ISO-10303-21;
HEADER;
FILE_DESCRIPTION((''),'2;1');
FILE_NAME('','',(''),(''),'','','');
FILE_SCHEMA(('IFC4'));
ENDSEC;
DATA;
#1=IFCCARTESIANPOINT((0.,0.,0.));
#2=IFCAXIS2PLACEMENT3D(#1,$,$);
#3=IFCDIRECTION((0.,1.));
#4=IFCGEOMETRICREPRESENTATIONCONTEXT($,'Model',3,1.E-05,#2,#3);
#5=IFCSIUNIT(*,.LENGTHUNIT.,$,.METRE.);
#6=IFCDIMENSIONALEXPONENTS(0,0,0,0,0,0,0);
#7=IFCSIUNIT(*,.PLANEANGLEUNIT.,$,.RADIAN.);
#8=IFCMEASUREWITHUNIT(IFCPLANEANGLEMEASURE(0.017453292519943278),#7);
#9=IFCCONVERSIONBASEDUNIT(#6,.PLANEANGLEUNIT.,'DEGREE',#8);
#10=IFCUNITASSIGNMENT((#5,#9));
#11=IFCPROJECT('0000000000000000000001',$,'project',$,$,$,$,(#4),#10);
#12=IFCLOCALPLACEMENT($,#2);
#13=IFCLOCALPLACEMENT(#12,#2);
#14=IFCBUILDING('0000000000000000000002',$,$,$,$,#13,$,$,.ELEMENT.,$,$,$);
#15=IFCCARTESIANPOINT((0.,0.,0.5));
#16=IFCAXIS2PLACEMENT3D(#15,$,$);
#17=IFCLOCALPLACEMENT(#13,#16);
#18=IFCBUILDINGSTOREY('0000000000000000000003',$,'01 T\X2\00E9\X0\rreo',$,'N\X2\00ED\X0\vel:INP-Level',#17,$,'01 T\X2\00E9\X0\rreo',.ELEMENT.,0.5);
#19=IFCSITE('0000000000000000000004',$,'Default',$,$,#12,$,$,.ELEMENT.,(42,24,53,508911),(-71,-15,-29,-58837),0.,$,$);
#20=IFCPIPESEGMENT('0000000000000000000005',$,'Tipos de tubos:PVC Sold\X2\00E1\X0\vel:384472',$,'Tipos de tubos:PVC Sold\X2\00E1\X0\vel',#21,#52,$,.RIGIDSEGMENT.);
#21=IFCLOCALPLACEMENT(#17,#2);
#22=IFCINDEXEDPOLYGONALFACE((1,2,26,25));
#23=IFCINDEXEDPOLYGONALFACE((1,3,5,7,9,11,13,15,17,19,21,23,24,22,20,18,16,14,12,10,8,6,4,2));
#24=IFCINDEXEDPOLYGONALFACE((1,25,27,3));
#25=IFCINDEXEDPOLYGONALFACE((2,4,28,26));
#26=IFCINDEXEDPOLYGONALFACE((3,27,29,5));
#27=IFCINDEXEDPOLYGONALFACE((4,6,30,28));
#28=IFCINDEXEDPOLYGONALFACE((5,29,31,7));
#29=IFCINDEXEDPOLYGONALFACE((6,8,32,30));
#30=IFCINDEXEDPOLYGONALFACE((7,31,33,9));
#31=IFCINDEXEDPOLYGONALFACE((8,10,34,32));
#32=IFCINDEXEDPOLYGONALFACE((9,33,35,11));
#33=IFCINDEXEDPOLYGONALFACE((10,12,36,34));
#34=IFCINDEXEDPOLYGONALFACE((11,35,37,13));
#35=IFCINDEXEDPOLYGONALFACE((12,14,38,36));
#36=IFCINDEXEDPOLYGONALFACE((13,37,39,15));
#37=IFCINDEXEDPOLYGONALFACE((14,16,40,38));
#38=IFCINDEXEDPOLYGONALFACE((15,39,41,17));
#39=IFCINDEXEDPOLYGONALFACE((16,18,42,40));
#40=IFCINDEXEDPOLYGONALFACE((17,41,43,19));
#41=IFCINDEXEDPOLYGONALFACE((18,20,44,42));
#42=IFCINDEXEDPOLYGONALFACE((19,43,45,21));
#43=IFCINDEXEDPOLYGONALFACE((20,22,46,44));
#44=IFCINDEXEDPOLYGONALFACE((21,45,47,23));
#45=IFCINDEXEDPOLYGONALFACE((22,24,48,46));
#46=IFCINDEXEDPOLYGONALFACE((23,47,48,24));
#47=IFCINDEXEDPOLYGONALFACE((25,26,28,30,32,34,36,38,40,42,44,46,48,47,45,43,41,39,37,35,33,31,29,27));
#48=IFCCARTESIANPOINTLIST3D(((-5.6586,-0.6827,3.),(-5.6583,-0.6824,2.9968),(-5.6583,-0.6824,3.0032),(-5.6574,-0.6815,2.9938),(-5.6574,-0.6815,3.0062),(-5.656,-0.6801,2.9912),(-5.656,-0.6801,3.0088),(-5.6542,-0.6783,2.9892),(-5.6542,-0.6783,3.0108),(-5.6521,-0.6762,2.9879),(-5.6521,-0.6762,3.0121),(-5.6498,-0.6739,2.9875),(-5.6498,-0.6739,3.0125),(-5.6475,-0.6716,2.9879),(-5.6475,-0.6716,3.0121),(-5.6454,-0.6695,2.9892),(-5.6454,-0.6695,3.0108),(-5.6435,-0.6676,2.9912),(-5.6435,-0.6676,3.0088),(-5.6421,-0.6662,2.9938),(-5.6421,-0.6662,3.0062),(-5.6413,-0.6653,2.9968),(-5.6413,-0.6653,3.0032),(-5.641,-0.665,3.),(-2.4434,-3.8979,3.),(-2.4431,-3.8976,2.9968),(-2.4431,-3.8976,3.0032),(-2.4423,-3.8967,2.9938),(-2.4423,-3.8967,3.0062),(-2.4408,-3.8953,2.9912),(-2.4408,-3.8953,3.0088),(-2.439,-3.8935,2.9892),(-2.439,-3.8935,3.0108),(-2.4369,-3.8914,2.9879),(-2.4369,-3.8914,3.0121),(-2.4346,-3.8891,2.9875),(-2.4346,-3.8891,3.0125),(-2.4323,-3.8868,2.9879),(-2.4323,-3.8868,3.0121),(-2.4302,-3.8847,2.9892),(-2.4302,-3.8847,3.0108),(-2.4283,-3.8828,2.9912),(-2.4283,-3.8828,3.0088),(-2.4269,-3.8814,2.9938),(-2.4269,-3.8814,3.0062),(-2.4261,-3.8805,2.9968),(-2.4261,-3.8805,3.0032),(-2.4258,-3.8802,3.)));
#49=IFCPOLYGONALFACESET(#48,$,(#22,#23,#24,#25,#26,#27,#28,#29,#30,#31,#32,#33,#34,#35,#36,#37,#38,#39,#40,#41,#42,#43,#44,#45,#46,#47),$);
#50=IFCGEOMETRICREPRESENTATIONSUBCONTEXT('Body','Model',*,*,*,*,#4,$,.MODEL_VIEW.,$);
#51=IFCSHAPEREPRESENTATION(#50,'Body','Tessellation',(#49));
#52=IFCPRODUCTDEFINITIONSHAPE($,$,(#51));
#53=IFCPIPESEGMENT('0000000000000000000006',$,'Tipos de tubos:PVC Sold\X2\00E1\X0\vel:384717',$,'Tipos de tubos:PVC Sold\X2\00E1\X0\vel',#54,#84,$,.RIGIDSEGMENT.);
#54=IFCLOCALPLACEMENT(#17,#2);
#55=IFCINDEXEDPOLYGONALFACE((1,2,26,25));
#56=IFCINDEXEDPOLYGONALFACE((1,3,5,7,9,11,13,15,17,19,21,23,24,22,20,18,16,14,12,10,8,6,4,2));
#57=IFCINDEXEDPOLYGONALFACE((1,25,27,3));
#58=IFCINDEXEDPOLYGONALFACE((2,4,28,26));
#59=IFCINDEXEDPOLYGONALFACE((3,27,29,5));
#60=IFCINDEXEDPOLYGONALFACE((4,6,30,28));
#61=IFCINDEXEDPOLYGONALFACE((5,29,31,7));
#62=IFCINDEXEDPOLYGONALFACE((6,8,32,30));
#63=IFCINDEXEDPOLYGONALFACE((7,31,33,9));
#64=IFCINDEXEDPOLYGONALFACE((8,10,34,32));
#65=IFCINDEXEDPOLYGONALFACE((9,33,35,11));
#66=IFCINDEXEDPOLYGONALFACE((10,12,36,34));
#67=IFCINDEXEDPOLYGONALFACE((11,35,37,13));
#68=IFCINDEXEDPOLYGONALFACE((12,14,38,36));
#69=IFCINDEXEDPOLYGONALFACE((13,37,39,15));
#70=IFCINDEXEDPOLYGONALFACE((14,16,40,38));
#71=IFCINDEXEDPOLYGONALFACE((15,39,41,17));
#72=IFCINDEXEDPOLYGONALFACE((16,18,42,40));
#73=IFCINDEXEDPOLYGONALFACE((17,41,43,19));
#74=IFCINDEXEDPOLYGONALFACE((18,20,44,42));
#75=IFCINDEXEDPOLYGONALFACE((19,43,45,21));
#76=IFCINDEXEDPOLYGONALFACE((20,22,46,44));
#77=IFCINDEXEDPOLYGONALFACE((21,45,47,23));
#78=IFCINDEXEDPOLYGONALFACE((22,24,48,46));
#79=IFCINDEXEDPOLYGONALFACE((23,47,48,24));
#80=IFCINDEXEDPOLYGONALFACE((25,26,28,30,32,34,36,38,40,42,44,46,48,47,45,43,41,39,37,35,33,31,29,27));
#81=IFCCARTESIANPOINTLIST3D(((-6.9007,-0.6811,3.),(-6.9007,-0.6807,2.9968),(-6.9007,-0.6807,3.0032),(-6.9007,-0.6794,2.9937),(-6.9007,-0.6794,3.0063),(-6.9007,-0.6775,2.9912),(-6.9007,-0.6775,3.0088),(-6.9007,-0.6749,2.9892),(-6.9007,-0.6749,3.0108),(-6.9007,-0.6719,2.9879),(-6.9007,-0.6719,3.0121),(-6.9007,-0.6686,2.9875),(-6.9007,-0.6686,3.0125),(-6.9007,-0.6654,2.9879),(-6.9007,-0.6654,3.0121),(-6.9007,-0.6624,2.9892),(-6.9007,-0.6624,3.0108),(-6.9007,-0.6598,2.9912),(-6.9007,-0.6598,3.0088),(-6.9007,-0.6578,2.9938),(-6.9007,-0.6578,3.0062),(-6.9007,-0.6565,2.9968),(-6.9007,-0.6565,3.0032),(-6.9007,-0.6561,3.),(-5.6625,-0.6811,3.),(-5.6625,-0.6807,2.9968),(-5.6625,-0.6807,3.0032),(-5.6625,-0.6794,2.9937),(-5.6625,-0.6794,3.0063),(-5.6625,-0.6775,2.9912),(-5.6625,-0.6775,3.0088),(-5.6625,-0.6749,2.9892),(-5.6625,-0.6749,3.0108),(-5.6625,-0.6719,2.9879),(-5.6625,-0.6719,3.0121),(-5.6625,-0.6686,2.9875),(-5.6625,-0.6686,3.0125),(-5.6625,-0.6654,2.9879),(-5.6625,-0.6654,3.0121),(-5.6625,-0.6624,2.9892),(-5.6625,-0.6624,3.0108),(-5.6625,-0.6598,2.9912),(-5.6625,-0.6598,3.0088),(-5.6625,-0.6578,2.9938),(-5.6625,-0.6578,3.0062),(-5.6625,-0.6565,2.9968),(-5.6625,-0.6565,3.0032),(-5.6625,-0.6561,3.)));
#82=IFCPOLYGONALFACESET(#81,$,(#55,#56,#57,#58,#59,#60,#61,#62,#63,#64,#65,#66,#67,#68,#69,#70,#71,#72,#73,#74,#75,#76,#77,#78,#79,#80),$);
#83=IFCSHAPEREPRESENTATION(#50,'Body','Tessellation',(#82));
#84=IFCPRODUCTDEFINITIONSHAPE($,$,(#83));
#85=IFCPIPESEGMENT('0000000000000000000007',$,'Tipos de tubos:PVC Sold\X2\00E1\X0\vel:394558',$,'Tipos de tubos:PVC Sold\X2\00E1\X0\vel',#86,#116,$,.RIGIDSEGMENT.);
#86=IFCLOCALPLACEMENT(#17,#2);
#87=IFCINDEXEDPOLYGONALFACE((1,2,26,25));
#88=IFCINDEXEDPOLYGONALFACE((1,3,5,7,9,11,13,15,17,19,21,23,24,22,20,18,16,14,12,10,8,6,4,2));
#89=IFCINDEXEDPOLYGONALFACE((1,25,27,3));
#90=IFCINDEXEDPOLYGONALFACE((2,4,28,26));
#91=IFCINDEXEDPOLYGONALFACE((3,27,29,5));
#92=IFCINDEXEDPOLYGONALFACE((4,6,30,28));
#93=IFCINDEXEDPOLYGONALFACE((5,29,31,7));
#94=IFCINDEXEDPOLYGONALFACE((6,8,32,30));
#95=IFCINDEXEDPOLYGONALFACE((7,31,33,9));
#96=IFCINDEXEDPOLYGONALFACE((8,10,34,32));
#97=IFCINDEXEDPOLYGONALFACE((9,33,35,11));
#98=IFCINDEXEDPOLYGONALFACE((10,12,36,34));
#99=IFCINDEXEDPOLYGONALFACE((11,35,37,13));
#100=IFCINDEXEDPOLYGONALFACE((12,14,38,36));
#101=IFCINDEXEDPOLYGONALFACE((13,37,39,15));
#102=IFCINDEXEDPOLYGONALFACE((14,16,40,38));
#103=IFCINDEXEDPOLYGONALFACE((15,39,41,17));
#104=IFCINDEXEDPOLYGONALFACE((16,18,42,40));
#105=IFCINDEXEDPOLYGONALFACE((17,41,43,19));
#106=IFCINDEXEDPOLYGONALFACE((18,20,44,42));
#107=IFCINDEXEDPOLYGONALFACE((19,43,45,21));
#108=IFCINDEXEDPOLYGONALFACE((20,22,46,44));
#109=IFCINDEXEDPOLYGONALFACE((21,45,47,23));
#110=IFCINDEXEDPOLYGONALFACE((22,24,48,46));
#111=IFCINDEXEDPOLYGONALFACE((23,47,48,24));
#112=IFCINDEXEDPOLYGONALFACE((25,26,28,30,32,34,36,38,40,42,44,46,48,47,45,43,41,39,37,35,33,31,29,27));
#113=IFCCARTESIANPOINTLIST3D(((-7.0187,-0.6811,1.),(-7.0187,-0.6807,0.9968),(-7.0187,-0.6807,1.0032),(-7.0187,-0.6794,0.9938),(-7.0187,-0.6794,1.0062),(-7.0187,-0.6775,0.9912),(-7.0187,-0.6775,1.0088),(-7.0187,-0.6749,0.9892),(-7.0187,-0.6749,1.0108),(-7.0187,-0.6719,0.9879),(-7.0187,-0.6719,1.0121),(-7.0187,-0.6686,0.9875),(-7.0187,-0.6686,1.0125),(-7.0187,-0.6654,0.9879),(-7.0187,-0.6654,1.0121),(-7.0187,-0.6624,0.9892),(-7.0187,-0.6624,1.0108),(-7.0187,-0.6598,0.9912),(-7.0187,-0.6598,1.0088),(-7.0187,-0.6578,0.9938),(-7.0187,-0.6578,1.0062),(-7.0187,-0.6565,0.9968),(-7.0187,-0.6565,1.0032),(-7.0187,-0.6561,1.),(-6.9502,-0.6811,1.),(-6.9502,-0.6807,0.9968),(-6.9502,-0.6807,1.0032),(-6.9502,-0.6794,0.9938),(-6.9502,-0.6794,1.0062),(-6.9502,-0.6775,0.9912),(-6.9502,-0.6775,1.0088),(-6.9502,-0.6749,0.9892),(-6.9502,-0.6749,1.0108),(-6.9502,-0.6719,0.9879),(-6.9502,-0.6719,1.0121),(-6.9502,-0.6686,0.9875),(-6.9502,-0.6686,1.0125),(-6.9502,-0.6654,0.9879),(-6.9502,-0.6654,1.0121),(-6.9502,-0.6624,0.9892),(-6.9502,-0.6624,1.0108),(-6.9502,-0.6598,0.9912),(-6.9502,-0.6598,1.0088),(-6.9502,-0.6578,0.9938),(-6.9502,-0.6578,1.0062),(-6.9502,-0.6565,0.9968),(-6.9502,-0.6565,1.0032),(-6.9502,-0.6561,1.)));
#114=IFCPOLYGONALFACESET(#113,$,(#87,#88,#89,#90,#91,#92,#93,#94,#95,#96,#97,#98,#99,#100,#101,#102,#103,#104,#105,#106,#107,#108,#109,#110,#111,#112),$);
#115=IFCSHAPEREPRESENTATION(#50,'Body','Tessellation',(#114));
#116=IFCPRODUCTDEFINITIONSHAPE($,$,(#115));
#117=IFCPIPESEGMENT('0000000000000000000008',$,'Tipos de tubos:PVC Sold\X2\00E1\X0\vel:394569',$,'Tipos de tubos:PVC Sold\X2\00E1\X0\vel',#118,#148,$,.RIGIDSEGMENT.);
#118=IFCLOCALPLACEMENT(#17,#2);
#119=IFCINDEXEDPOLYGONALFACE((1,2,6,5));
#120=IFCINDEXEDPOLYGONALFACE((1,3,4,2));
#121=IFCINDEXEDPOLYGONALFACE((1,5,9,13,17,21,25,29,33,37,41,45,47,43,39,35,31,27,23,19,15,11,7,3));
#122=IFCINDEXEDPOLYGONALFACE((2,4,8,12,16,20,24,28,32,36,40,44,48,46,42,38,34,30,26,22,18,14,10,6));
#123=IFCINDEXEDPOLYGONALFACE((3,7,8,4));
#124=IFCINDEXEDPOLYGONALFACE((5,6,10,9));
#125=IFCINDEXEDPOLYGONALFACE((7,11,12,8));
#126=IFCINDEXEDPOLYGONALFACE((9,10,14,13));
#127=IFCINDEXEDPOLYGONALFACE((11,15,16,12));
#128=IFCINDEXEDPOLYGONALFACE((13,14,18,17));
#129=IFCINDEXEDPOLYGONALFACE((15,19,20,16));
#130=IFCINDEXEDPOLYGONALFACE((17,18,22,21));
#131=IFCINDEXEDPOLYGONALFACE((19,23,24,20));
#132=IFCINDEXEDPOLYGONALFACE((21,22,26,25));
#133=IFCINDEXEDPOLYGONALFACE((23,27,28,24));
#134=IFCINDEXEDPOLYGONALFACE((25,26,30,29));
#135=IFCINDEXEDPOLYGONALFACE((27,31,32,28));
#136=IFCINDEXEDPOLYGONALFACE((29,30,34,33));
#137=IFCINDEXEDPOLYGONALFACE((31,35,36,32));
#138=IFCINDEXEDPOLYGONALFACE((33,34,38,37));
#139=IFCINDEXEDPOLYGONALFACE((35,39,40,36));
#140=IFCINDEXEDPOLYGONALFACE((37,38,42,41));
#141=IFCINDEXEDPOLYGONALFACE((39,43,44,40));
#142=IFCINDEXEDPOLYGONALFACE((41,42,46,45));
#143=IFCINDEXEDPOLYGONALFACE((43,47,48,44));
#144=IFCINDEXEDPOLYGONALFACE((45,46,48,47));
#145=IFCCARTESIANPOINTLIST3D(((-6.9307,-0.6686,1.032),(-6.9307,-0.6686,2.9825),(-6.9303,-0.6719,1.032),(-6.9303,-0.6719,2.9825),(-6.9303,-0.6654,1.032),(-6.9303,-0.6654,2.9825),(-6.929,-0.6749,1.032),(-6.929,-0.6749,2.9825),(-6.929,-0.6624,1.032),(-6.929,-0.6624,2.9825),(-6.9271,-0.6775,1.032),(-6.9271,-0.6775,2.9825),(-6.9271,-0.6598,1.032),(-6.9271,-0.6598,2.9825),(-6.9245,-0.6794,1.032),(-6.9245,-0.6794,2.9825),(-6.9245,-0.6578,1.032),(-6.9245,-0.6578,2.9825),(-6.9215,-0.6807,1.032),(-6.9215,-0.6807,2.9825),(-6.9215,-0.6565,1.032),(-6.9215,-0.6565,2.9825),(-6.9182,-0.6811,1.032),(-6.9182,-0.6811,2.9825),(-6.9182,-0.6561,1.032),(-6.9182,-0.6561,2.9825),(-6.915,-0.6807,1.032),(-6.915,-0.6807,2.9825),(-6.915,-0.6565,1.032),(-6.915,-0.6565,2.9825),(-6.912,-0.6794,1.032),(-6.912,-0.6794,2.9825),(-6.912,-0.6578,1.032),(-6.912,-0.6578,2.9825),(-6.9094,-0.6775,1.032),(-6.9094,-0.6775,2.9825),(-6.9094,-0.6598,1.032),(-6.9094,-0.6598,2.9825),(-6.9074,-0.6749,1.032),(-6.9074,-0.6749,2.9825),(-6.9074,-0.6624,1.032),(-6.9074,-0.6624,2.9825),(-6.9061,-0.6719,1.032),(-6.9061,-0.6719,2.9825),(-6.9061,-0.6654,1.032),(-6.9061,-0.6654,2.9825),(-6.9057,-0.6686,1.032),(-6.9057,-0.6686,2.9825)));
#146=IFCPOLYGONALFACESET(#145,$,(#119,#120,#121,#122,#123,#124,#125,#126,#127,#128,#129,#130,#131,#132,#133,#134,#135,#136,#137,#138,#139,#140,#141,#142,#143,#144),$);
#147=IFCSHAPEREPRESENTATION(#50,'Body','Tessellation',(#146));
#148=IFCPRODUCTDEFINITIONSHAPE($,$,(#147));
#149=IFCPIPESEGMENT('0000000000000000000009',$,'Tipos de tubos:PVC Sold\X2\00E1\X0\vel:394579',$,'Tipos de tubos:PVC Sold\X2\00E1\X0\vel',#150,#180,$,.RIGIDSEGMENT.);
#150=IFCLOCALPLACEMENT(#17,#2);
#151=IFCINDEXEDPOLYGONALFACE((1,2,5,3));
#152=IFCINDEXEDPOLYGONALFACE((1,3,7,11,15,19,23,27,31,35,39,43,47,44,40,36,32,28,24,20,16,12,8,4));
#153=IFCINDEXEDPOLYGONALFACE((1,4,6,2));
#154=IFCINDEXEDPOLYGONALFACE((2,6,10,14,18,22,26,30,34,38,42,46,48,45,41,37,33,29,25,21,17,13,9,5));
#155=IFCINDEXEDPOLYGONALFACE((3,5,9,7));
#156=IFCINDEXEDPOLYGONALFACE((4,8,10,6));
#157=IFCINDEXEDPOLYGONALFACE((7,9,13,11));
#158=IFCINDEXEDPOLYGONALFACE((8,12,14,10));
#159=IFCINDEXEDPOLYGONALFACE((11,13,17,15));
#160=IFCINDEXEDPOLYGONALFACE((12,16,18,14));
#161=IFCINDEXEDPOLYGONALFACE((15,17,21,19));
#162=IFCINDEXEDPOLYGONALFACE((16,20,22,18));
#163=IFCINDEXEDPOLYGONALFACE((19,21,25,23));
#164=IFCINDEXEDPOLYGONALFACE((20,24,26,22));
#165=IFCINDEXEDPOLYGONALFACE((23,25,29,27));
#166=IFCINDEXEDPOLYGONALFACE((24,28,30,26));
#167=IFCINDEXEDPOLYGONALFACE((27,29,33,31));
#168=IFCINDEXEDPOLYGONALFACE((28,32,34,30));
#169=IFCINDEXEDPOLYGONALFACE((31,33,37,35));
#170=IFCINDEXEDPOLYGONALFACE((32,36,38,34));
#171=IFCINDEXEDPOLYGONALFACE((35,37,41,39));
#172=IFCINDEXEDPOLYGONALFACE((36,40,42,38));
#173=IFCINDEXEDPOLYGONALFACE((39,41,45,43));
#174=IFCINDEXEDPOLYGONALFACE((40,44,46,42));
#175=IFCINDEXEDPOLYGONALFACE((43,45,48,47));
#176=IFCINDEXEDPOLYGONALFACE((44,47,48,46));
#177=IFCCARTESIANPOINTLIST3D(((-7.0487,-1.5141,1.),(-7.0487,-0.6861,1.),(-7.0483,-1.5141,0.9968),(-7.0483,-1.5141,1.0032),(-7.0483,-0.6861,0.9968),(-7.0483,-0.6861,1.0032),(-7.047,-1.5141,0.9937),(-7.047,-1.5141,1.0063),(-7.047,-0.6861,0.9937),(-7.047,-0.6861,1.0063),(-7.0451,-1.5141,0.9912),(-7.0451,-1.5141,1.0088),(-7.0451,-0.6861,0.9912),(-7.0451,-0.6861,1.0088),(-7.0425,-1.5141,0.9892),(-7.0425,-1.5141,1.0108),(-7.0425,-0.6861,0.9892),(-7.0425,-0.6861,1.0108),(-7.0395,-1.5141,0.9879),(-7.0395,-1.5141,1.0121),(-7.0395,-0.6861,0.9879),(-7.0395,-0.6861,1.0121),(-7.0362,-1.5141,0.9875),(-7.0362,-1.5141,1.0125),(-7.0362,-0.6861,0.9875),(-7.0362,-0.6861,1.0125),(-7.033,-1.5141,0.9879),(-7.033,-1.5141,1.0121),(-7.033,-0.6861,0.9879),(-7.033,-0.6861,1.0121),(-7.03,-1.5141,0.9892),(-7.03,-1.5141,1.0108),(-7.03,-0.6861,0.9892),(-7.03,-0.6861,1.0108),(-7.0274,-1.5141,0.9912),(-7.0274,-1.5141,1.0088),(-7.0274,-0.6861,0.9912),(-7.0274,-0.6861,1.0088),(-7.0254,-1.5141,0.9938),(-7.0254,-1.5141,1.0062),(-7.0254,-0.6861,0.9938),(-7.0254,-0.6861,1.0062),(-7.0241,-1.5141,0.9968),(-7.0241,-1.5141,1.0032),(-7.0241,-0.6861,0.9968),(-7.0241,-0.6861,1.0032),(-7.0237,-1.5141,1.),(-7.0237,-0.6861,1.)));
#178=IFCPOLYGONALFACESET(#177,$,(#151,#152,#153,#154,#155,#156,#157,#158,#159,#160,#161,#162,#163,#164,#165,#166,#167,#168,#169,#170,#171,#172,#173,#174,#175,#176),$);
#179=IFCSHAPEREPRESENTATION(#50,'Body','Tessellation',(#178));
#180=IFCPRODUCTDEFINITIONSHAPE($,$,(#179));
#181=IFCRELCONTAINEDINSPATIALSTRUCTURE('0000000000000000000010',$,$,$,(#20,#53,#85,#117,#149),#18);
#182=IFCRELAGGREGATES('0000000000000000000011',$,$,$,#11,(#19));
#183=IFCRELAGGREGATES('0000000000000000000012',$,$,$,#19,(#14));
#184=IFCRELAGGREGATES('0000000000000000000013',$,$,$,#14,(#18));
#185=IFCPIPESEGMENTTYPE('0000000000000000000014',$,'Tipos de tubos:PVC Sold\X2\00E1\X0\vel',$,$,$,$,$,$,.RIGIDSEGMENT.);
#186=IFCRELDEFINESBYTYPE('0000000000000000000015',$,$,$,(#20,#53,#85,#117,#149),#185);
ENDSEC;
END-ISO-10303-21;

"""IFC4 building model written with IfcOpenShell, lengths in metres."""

from ifc_helpers import new_model, entity, si_unit, converted_unit, direction, frame, origin, place, context, subcontext, project, spatial, arc, indexed_curve, outline, extrude, type_object, element, save


model = new_model("IFC4")

# Units and contexts
model_context = context("Model", 3, precision=1e-05, world=origin(), true_north=direction((0.0, 1.0)))
body_context = subcontext(model_context, "Body", "Model", "MODEL_VIEW")
ifc_project = project(units=[si_unit("LENGTHUNIT", "METRE"), converted_unit("PLANEANGLEUNIT", "DEGREE", entity("IfcPlaneAngleMeasure", 0.017453292519943278), si_unit("PLANEANGLEUNIT", "RADIAN"), dimensions=[0, 0, 0, 0, 0, 0, 0])], contexts=[model_context])

# Site, building, storey
site_placement = place(None, origin())
site = spatial("IfcSite", under=ifc_project, at=site_placement, Name="Default", CompositionType="ELEMENT", RefLatitude=(42, 24, 53, 508911), RefLongitude=(-71, -15, -29, -58837), RefElevation=0.0)
building_placement = place(site_placement, origin())
building = spatial("IfcBuilding", under=site, at=building_placement, CompositionType="ELEMENT")
storey_placement = place(building_placement, frame((0.0, 0.0, 0.5)))
storey = spatial("IfcBuildingStorey", under=building, at=storey_placement, Name="01 Térreo", ObjectType="Nível:INP-Level", LongName="01 Térreo", CompositionType="ELEMENT", Elevation=0.5)

# Pipe segments
pipe_segment_type = type_object("IfcPipeSegmentType", Name="Tipos de tubos:PVC Soldável", PredefinedType="RIGIDSEGMENT")
pipe_segment_1_placement = place(storey_placement, origin())
element("IfcPipeSegment", 1, at=pipe_segment_1_placement, inside=storey, type_object=pipe_segment_type, Name="Tipos de tubos:PVC Soldável:384472", ObjectType="Tipos de tubos:PVC Soldável", PredefinedType="RIGIDSEGMENT", context=body_context, shape_type="SweptSolid", body=[
    extrude(outline(indexed_curve([(0.0125, 0.0), (0.0088, 0.0088), (0.0, 0.0125), (-0.0088, 0.0088), (-0.0125, 0.0), (-0.0088, -0.0088), (0.0, -0.0125), (0.0088, -0.0088)], segments=[arc(1, 2, 3), arc(3, 4, 5), arc(5, 6, 7), arc(7, 8, 1)], self_intersect=False)), frame((-2.4346, -3.8891, 3.0), z_axis=(-0.707107, 0.707107, 0.0), x_axis=(-0.707107, -0.707107, 0.0)), (0.0, 0.0, 1.0), 4.547),
])
pipe_segment_2_placement = place(storey_placement, origin())
element("IfcPipeSegment", 2, at=pipe_segment_2_placement, inside=storey, type_object=pipe_segment_type, Name="Tipos de tubos:PVC Soldável:384717", ObjectType="Tipos de tubos:PVC Soldável", PredefinedType="RIGIDSEGMENT", context=body_context, shape_type="SweptSolid", body=[
    extrude(outline(indexed_curve([(0.0125, 0.0), (0.0088, 0.0088), (0.0, 0.0125), (-0.0088, 0.0088), (-0.0125, 0.0), (-0.0088, -0.0088), (0.0, -0.0125), (0.0088, -0.0088)], segments=[arc(1, 2, 3), arc(3, 4, 5), arc(5, 6, 7), arc(7, 8, 1)], self_intersect=False)), frame((-6.9007, -0.6686, 3.0), z_axis=(1.0, 0.0, 0.0), x_axis=(0.0, 1.0, 0.0)), (0.0, 0.0, 1.0), 1.2382),
])
pipe_segment_3_placement = place(storey_placement, origin())
element("IfcPipeSegment", 3, at=pipe_segment_3_placement, inside=storey, type_object=pipe_segment_type, Name="Tipos de tubos:PVC Soldável:394558", ObjectType="Tipos de tubos:PVC Soldável", PredefinedType="RIGIDSEGMENT", context=body_context, shape_type="SweptSolid", body=[
    extrude(outline(indexed_curve([(0.0125, 0.0), (0.0088, 0.0088), (0.0, 0.0125), (-0.0088, 0.0088), (-0.0125, 0.0), (-0.0088, -0.0088), (0.0, -0.0125), (0.0088, -0.0088)], segments=[arc(1, 2, 3), arc(3, 4, 5), arc(5, 6, 7), arc(7, 8, 1)], self_intersect=False)), frame((-7.0187, -0.6686, 1.0), z_axis=(1.0, 0.0, 0.0), x_axis=(0.0, 1.0, 0.0)), (0.0, 0.0, 1.0), 0.0685),
])
pipe_segment_4_placement = place(storey_placement, origin())
element("IfcPipeSegment", 4, at=pipe_segment_4_placement, inside=storey, type_object=pipe_segment_type, Name="Tipos de tubos:PVC Soldável:394569", ObjectType="Tipos de tubos:PVC Soldável", PredefinedType="RIGIDSEGMENT", context=body_context, shape_type="SweptSolid", body=[
    extrude(outline(indexed_curve([(0.0125, 0.0), (0.0088, 0.0088), (0.0, 0.0125), (-0.0088, 0.0088), (-0.0125, 0.0), (-0.0088, -0.0088), (0.0, -0.0125), (0.0088, -0.0088)], segments=[arc(1, 2, 3), arc(3, 4, 5), arc(5, 6, 7), arc(7, 8, 1)], self_intersect=False)), frame((-6.9182, -0.6686, 1.032)), (0.0, 0.0, 1.0), 1.9505),
])
pipe_segment_5_placement = place(storey_placement, origin())
element("IfcPipeSegment", 5, at=pipe_segment_5_placement, inside=storey, type_object=pipe_segment_type, Name="Tipos de tubos:PVC Soldável:394579", ObjectType="Tipos de tubos:PVC Soldável", PredefinedType="RIGIDSEGMENT", context=body_context, shape_type="SweptSolid", body=[
    extrude(outline(indexed_curve([(0.0125, 0.0), (0.0088, 0.0088), (0.0, 0.0125), (-0.0088, 0.0088), (-0.0125, 0.0), (-0.0088, -0.0088), (0.0, -0.0125), (0.0088, -0.0088)], segments=[arc(1, 2, 3), arc(3, 4, 5), arc(5, 6, 7), arc(7, 8, 1)], self_intersect=False)), frame((-7.0362, -1.5141, 1.0), z_axis=(0.0, 1.0, 0.0), x_axis=(-1.0, 0.0, 0.0)), (0.0, 0.0, 1.0), 0.828),
])

save(model, "model.ifc")
